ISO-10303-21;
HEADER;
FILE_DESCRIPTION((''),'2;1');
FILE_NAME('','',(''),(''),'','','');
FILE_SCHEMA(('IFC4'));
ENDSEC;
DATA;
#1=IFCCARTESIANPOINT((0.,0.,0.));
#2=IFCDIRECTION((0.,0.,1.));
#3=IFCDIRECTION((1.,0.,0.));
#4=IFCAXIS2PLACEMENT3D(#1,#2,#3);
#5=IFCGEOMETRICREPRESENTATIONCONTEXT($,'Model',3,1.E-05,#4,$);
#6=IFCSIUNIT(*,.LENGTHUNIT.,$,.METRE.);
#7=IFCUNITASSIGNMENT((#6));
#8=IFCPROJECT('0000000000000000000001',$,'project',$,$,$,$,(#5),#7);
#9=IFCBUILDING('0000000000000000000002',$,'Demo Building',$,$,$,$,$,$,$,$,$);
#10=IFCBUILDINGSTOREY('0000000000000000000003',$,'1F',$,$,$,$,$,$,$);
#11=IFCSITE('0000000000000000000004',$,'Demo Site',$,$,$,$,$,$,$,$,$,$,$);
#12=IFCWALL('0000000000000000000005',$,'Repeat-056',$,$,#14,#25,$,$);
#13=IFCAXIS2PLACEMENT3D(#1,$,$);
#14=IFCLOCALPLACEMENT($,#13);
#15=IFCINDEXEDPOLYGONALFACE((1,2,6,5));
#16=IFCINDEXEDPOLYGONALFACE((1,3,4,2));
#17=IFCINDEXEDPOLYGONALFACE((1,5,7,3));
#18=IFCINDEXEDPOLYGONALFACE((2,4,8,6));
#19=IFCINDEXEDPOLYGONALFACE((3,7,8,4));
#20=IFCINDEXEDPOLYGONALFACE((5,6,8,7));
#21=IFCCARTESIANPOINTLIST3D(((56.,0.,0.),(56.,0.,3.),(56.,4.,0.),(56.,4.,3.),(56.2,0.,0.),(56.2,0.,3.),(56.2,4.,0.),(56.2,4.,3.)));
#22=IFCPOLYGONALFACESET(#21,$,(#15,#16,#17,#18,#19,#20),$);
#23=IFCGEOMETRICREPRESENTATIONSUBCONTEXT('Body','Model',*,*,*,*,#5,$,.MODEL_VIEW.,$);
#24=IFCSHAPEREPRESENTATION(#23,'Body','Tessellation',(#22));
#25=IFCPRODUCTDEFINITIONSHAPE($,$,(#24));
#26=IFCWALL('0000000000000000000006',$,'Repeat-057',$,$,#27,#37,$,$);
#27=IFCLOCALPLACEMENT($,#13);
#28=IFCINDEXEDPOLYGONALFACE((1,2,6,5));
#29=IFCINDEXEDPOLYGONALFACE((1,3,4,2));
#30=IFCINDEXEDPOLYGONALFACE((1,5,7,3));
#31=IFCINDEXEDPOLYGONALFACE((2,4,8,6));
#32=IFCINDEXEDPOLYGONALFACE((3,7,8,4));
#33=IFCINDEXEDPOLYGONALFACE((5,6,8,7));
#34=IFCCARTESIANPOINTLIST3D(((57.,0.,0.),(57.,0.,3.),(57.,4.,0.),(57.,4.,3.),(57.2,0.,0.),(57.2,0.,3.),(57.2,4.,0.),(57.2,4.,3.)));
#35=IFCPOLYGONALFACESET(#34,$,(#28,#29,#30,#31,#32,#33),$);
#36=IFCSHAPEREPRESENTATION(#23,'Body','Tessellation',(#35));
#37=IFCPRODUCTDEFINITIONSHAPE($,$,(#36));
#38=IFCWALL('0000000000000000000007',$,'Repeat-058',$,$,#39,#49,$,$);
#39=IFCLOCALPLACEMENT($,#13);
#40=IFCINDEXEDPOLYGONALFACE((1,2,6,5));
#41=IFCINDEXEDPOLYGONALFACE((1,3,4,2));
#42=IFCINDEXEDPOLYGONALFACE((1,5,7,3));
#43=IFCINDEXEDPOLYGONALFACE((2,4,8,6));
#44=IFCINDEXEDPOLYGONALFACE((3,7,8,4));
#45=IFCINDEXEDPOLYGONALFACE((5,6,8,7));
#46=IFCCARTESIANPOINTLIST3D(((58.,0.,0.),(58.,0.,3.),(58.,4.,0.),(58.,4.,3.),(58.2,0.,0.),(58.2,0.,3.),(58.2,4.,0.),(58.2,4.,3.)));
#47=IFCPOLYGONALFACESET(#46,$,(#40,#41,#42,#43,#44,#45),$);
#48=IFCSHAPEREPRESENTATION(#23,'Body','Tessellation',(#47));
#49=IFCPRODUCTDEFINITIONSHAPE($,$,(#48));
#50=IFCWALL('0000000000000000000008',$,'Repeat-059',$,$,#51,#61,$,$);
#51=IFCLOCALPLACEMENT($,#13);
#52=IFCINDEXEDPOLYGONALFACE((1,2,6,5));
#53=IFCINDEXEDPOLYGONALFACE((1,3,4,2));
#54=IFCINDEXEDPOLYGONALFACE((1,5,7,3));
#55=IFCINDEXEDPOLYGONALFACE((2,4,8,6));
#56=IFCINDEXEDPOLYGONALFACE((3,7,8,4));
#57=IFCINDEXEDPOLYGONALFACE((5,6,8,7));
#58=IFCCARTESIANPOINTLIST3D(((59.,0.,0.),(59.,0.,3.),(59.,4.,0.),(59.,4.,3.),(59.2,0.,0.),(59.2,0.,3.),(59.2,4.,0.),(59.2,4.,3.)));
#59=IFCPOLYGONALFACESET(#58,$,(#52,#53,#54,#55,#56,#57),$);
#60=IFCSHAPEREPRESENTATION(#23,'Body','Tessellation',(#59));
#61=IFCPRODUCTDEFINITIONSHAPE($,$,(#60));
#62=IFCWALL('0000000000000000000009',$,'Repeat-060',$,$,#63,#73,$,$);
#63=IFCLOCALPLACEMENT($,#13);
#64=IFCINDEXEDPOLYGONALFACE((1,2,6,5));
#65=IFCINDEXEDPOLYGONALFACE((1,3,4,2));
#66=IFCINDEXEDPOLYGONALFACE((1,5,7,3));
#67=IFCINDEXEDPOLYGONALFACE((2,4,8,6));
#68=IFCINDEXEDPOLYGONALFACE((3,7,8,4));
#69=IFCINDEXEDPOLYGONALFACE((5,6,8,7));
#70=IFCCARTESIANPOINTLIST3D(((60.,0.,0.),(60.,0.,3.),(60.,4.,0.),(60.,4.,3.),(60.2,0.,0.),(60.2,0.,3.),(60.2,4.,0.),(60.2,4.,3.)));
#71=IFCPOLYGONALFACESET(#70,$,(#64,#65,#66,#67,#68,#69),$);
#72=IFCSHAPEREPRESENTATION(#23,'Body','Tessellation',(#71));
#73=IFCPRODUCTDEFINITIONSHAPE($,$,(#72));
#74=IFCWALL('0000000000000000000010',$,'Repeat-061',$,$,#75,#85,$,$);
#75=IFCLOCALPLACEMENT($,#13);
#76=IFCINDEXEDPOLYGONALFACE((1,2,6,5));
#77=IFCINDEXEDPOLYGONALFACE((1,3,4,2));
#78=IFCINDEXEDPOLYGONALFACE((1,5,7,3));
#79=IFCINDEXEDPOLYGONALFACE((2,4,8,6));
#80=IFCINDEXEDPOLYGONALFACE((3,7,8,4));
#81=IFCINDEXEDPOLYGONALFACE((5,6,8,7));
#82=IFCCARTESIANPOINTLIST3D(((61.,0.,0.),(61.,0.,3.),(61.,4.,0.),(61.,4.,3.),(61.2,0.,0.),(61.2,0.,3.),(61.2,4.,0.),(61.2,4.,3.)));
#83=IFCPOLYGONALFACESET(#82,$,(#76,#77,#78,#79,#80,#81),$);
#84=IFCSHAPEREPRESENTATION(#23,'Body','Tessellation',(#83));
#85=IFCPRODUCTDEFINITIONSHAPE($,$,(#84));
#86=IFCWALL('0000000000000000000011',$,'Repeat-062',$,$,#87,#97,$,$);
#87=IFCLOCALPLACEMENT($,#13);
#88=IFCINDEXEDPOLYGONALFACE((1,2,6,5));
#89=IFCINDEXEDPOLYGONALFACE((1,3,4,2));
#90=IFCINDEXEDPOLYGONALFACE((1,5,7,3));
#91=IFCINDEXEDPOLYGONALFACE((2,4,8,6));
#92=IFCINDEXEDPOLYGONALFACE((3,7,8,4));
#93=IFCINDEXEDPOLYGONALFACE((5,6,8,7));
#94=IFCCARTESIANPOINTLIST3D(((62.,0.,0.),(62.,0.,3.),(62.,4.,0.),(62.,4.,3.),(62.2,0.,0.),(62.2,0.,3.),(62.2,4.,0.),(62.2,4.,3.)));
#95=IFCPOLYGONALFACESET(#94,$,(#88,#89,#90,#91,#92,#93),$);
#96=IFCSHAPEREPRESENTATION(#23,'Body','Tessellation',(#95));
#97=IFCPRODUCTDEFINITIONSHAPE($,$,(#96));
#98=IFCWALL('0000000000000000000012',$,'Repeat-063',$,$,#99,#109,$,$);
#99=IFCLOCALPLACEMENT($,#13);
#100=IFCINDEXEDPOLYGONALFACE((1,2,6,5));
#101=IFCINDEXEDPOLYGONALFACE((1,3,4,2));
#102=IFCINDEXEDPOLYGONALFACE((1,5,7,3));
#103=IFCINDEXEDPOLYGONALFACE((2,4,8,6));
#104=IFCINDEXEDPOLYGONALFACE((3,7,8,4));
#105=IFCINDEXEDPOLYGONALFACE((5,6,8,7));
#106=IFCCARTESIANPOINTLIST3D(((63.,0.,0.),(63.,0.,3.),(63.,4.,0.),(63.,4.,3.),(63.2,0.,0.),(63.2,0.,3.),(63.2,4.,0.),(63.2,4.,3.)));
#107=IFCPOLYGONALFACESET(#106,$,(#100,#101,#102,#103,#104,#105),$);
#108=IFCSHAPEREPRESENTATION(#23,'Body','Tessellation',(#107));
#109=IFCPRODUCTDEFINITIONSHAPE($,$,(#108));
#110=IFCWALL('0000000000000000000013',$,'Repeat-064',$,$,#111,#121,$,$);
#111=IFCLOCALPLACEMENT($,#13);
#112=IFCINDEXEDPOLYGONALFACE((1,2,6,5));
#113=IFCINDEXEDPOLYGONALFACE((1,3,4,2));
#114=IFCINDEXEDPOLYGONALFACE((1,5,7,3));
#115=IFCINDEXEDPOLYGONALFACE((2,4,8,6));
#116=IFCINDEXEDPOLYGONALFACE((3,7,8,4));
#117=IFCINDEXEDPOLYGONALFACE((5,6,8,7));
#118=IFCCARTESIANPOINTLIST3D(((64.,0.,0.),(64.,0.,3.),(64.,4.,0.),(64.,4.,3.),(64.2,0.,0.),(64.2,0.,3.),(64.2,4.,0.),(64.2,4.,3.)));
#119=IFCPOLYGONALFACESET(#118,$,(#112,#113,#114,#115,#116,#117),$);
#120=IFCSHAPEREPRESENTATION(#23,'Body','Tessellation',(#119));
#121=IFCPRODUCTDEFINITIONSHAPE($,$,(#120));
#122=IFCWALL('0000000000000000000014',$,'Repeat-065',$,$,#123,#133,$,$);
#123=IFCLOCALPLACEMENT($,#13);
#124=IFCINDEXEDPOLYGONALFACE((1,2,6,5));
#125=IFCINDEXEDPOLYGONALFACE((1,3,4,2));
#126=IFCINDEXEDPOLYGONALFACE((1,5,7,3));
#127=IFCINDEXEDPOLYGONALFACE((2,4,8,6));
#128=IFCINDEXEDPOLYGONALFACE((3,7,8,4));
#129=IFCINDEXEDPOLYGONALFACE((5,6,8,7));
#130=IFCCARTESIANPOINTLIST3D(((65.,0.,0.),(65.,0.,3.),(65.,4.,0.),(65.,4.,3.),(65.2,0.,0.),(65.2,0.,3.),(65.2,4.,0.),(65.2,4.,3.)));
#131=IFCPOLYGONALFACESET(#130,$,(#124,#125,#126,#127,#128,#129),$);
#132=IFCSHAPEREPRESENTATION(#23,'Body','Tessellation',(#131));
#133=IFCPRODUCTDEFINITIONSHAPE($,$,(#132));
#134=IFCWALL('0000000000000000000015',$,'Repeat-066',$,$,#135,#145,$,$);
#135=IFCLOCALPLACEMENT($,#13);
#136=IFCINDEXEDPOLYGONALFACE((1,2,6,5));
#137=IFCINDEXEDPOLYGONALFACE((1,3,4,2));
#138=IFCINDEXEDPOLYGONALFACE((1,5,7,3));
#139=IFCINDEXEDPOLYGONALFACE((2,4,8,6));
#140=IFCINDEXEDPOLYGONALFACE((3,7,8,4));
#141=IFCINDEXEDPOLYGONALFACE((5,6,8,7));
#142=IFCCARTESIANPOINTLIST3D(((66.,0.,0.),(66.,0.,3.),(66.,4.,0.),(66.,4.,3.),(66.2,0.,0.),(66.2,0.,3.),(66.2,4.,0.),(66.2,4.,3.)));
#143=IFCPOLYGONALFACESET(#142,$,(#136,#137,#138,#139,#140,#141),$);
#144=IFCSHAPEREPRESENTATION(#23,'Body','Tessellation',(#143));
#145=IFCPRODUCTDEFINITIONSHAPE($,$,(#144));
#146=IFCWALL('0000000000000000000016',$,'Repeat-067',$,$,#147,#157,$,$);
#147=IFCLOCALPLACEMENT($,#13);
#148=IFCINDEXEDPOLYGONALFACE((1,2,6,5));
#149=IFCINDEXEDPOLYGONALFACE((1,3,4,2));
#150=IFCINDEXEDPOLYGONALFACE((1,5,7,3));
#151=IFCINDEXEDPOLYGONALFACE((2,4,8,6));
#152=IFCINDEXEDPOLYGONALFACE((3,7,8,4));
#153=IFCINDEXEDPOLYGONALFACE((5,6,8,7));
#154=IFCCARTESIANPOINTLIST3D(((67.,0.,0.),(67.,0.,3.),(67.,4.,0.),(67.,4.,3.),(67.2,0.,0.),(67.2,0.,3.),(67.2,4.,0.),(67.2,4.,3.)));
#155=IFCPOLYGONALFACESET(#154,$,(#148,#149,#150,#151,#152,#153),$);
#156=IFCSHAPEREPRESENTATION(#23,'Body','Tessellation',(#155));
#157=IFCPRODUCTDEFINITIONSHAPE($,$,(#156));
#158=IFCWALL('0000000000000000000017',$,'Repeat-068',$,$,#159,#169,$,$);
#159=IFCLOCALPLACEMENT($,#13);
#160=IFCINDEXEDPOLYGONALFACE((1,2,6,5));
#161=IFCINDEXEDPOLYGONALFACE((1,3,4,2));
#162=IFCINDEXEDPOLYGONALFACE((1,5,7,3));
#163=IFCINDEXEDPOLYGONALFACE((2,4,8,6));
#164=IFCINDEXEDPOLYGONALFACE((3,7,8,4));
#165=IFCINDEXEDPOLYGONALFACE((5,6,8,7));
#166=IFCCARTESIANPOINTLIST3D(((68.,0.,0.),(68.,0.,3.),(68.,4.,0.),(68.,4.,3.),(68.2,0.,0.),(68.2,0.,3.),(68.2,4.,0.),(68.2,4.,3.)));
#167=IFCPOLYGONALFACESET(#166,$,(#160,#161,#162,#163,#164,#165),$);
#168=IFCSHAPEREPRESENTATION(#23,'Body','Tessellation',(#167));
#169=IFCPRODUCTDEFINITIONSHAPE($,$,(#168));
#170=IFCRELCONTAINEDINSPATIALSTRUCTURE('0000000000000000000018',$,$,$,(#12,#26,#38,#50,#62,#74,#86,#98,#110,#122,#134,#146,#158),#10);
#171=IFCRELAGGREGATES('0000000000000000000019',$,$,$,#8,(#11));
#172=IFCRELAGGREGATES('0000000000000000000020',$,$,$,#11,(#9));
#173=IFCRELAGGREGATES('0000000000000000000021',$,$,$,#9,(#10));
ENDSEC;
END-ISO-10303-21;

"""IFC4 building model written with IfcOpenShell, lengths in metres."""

from ifc_helpers import new_model, entity, si_unit, frame, origin_with_axes, place, context, subcontext, project, spatial, element, save


model = new_model("IFC4")

# Units and contexts
model_context = context("Model", 3, precision=1e-05, world=origin_with_axes())
body_context = subcontext(model_context, "Body", "Model", "MODEL_VIEW")
ifc_project = project(units=[si_unit("LENGTHUNIT", "METRE")], contexts=[model_context])

# Site, building, storey
site = spatial("IfcSite", under=ifc_project, Name="Demo Site")
building = spatial("IfcBuilding", under=site, Name="Demo Building")
storey = spatial("IfcBuildingStorey", under=building, Name="1F")

# Walls
for number, where, z_axis, x_axis, name in (
    (1, (56.0, 0.0, 0.0), (0.0, 0.0, 1.0), (1.0, 0.0, 0.0), "Repeat-056"),
    (2, (57.0, 0.0, 0.0), (0.0, 0.0, 1.0), (1.0, 0.0, 0.0), "Repeat-057"),
    (3, (58.0, 0.0, 0.0), (0.0, 0.0, 1.0), (1.0, 0.0, 0.0), "Repeat-058"),
    (4, (59.0, 0.0, 0.0), (0.0, 0.0, 1.0), (1.0, 0.0, 0.0), "Repeat-059"),
    (5, (60.0, 0.0, 0.0), (0.0, 0.0, 1.0), (1.0, 0.0, 0.0), "Repeat-060"),
    (6, (61.0, 0.0, 0.0), (0.0, 0.0, 1.0), (1.0, 0.0, 0.0), "Repeat-061"),
    (7, (62.0, 0.0, 0.0), (0.0, 0.0, 1.0), (1.0, 0.0, 0.0), "Repeat-062"),
    (8, (63.0, 0.0, 0.0), (0.0, 0.0, 1.0), (1.0, 0.0, 0.0), "Repeat-063"),
    (9, (64.0, 0.0, 0.0), (0.0, 0.0, 1.0), (1.0, 0.0, 0.0), "Repeat-064"),
    (10, (65.0, 0.0, 0.0), (0.0, 0.0, 1.0), (1.0, 0.0, 0.0), "Repeat-065"),
    (11, (66.0, 0.0, 0.0), (0.0, 0.0, 1.0), (1.0, 0.0, 0.0), "Repeat-066"),
    (12, (67.0, 0.0, 0.0), (0.0, 0.0, 1.0), (1.0, 0.0, 0.0), "Repeat-067"),
    (13, (68.0, 0.0, 0.0), (0.0, 0.0, 1.0), (1.0, 0.0, 0.0), "Repeat-068"),
):
    element("IfcWall", number, at=place(None, frame(where, z_axis=z_axis, x_axis=x_axis)), inside=storey, Name=name, context=body_context, shape_type="CSG", body=[
        entity("IfcBlock", entity("IfcAxis2Placement3D", entity("IfcCartesianPoint", [0.0, 0.0, 0.0]), entity("IfcDirection", [0.0, 0.0, 1.0]), entity("IfcDirection", [1.0, 0.0, 0.0])), 0.2, 4.0, 3.0),
    ])

save(model, "model.ifc")
